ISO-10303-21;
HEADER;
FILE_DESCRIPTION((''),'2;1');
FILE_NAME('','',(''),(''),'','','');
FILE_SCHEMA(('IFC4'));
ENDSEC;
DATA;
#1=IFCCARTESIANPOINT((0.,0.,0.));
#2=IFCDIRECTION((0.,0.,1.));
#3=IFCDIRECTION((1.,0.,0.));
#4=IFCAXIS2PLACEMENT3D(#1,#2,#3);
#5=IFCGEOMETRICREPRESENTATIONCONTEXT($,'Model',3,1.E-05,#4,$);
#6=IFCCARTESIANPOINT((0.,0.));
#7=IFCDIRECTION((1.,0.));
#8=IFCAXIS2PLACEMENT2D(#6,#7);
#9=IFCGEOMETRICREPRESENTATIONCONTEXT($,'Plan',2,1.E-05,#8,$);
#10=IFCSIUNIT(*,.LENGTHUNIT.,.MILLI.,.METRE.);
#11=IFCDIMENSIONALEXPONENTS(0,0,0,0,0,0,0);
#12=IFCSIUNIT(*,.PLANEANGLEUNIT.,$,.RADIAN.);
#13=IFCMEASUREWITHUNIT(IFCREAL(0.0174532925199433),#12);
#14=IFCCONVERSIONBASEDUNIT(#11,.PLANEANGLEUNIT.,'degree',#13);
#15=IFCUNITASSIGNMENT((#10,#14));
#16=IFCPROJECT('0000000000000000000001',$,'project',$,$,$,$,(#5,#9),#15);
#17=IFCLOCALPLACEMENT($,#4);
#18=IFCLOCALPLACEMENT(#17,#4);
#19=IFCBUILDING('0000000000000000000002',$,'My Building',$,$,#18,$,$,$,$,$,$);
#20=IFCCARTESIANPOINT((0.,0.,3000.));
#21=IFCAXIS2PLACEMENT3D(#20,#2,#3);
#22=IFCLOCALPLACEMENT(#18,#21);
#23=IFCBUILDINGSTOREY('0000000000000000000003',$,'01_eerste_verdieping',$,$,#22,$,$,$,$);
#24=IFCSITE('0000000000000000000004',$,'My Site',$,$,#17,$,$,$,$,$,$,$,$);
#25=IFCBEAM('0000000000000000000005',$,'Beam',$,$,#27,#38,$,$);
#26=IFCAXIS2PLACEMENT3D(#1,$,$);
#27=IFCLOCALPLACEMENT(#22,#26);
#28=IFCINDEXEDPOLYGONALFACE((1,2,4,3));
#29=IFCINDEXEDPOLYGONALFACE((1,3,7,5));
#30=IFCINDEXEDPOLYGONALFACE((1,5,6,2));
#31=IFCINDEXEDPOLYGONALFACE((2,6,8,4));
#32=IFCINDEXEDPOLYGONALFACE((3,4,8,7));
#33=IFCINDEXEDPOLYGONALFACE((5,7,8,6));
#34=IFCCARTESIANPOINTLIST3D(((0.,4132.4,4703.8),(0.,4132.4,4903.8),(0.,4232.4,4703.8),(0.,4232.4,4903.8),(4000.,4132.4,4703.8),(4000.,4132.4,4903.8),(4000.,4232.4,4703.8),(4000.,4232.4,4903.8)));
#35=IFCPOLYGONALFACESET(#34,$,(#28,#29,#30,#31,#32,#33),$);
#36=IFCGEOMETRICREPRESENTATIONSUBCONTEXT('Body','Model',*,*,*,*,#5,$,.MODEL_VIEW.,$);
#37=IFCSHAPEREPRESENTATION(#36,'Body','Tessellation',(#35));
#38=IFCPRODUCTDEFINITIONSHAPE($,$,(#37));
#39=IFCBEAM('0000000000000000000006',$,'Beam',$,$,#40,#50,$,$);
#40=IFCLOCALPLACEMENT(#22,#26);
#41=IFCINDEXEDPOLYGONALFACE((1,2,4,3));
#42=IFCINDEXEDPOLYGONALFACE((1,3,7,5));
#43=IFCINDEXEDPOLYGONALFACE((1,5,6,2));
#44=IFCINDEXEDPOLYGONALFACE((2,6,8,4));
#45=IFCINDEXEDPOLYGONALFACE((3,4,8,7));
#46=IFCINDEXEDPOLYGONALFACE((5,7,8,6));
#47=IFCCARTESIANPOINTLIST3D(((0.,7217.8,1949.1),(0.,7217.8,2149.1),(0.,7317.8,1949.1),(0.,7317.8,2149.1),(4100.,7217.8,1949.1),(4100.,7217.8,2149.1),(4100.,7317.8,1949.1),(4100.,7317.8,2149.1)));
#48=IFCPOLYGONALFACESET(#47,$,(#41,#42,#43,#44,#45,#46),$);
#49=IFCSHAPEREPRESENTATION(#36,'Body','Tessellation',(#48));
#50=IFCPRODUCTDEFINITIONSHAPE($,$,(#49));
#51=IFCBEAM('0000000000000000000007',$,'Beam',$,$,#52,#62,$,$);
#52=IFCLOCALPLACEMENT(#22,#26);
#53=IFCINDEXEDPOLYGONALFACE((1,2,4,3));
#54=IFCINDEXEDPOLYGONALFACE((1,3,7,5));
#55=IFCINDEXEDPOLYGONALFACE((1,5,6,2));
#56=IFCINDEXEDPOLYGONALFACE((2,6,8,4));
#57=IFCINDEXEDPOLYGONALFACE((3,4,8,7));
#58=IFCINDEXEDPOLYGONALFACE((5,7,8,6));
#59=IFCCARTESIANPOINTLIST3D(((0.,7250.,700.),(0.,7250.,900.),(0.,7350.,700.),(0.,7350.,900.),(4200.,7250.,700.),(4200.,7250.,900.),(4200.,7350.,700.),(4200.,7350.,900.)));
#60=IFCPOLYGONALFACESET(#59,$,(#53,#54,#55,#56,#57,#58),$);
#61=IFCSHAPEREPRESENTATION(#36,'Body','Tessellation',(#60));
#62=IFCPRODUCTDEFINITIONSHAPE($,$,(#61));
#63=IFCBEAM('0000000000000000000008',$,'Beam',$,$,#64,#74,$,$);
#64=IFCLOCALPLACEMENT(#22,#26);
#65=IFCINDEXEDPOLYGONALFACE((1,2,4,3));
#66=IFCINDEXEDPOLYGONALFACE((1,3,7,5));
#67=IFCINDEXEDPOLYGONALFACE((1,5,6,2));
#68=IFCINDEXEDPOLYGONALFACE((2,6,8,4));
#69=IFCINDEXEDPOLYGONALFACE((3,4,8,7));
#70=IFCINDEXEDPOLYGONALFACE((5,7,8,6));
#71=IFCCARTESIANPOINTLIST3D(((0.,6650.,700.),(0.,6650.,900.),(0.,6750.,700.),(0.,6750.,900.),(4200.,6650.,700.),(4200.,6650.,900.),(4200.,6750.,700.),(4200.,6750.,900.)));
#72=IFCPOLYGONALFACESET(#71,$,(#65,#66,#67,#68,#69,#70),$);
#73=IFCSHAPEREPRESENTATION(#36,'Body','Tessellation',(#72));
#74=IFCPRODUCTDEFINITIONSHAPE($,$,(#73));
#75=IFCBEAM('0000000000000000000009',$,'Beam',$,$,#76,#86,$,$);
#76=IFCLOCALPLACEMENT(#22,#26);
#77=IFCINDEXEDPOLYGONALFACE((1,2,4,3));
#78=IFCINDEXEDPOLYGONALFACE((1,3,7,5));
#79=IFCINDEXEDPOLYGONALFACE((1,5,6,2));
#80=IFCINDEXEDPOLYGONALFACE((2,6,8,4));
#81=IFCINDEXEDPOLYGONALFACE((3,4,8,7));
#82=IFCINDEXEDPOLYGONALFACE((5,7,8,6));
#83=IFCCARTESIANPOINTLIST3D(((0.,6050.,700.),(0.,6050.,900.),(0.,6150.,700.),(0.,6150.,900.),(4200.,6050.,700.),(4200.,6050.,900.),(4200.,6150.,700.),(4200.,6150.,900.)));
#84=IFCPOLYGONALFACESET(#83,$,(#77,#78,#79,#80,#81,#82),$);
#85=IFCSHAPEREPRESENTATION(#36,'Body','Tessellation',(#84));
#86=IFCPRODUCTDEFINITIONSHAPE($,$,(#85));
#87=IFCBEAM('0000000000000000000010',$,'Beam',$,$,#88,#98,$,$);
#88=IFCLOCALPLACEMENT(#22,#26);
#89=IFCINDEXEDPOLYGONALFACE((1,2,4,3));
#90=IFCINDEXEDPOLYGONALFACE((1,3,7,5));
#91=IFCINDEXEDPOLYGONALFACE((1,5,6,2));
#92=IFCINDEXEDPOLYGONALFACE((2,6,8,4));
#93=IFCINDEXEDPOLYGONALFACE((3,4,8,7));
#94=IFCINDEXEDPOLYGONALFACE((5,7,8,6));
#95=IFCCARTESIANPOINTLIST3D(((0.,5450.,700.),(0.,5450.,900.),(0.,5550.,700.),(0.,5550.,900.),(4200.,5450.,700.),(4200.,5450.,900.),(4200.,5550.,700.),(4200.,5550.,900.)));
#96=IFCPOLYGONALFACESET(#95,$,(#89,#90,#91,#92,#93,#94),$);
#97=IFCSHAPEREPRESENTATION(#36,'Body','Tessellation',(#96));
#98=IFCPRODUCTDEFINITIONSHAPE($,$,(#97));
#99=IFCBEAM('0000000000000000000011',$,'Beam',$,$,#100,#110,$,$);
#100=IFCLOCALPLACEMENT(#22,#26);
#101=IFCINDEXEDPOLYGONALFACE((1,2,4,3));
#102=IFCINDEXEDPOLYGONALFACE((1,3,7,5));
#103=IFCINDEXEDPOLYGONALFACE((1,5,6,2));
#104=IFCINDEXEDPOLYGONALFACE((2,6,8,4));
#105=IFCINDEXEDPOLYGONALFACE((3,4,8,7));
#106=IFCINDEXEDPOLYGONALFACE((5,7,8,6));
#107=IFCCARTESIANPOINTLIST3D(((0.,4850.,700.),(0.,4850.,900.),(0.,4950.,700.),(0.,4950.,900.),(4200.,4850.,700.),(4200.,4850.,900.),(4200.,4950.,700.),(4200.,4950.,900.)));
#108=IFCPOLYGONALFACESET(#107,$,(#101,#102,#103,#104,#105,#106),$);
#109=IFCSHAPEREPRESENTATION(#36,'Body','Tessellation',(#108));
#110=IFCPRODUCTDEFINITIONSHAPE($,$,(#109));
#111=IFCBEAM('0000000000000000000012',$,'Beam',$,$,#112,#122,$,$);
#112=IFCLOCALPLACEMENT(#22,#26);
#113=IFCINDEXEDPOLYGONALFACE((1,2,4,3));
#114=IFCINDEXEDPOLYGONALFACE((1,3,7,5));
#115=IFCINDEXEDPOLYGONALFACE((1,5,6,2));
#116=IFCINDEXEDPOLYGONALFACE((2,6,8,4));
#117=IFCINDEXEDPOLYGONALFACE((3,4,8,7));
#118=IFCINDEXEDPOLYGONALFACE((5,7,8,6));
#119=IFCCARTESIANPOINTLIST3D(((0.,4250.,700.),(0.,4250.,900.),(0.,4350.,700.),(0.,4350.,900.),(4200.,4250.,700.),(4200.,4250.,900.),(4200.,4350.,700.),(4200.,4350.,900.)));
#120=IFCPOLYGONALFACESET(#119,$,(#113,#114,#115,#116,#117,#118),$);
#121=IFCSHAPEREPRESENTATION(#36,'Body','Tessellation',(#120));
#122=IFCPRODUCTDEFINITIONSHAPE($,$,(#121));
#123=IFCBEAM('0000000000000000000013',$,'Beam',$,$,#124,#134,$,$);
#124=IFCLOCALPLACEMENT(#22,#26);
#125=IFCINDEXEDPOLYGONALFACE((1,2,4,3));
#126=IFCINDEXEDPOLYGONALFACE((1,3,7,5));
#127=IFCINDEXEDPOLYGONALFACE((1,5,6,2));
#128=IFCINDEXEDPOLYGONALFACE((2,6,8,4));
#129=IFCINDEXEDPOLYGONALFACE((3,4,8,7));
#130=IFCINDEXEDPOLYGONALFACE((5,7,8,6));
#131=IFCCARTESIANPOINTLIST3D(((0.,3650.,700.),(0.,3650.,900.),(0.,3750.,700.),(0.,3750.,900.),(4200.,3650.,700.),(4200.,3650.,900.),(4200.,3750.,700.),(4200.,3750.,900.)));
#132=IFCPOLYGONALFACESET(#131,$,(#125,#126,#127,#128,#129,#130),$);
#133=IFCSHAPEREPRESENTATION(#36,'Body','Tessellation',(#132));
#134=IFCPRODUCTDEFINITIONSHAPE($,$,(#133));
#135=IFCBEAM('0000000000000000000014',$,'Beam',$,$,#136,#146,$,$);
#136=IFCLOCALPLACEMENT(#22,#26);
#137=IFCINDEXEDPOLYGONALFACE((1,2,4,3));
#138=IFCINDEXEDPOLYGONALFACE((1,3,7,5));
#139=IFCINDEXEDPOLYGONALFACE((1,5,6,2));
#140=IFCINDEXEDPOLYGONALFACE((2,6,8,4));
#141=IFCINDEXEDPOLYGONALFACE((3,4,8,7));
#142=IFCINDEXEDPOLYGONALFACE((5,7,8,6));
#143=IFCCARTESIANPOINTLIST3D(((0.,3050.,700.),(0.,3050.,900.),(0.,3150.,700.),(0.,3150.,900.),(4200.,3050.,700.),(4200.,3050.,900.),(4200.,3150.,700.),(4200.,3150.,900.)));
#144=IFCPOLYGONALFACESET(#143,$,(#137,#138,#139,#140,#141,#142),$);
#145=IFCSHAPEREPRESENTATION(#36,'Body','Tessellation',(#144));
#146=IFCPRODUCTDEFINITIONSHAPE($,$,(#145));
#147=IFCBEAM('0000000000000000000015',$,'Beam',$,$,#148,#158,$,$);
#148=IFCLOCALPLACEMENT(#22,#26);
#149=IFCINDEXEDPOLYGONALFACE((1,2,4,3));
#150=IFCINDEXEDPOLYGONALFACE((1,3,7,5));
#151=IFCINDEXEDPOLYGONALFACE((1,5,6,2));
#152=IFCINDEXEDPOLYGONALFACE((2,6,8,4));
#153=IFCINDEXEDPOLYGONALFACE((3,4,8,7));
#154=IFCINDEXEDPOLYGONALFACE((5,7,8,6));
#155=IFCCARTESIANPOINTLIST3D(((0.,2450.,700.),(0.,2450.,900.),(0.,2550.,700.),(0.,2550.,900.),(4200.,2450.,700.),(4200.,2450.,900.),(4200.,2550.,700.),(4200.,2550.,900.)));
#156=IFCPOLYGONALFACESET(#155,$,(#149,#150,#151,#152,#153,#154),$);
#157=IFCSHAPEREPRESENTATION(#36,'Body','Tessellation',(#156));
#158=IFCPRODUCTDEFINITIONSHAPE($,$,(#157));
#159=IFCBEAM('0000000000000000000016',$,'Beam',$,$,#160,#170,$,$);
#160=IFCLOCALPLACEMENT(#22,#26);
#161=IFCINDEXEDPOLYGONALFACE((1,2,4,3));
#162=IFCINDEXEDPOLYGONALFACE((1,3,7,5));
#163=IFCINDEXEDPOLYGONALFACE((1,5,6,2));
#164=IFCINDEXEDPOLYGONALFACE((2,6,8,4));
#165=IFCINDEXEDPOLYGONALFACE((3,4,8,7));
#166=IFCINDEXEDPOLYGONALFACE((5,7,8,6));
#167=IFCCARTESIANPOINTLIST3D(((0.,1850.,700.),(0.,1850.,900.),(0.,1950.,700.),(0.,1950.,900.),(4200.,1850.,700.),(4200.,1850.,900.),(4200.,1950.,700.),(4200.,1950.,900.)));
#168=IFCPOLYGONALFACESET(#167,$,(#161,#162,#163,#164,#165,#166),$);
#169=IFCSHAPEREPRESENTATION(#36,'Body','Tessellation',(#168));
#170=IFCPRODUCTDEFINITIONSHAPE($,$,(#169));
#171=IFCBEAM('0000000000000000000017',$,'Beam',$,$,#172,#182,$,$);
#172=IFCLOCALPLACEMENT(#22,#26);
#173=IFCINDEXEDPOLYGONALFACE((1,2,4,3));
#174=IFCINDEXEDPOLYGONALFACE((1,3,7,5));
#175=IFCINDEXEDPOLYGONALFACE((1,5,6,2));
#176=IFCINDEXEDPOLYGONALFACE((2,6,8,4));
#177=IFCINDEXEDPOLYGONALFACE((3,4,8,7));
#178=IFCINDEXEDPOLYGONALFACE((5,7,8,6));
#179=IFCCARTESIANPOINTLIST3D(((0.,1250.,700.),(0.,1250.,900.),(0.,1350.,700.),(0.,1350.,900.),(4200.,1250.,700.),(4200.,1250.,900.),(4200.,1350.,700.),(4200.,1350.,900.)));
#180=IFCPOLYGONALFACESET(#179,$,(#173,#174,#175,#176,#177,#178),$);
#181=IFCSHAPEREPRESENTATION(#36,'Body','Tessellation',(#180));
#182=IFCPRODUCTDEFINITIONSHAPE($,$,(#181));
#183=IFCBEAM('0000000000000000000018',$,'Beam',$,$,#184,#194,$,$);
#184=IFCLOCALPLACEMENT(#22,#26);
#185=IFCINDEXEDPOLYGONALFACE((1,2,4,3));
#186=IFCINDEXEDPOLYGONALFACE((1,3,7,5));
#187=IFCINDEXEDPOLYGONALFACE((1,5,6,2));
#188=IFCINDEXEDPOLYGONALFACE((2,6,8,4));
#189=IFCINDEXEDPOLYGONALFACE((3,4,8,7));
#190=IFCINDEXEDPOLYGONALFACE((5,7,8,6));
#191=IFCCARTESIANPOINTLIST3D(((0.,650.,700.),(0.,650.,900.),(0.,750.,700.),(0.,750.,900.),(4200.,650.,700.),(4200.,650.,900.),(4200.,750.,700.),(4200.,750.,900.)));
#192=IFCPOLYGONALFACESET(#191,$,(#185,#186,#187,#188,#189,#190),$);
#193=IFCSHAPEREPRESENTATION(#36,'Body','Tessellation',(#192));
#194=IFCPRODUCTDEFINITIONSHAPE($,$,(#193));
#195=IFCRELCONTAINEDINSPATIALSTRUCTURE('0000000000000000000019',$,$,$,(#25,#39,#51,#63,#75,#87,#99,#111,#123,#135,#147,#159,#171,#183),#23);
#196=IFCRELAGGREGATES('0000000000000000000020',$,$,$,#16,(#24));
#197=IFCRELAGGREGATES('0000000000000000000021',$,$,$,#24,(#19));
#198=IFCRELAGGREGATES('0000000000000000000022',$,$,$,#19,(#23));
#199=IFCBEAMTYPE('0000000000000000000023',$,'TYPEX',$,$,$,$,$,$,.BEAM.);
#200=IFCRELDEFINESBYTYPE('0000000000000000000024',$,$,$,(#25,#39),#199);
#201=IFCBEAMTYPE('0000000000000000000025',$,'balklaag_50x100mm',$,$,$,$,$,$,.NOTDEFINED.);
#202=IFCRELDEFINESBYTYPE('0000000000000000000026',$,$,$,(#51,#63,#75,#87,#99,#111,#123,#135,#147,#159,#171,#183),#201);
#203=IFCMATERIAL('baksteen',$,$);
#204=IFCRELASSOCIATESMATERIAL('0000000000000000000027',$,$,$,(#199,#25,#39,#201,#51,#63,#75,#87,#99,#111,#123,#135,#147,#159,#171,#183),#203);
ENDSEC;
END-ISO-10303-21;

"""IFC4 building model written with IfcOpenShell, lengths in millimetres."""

from ifc_helpers import new_model, entity, si_unit, converted_unit, frame, origin_with_axes, origin_2d_with_axis, place, context, subcontext, project, spatial, rectangle, extrude, material, material_profile, profile_set, profile_usage, type_object, element, save


model = new_model("IFC4")

# Units and contexts
model_context = context("Model", 3, precision=1e-05, world=origin_with_axes())
plan_context = context("Plan", 2, precision=1e-05, world=origin_2d_with_axis())
body_context = subcontext(model_context, "Body", "Model", "MODEL_VIEW")
ifc_project = project(units=[si_unit("LENGTHUNIT", "METRE", prefix="MILLI"), converted_unit("PLANEANGLEUNIT", "degree", entity("IfcReal", 0.0174532925199433), si_unit("PLANEANGLEUNIT", "RADIAN"), dimensions=[0, 0, 0, 0, 0, 0, 0])], contexts=[model_context, plan_context])

# Site, building, storey
site_placement = place(None, origin_with_axes())
site = spatial("IfcSite", under=ifc_project, at=site_placement, Name="My Site")
building_placement = place(site_placement, origin_with_axes())
building = spatial("IfcBuilding", under=site, at=building_placement, Name="My Building")
storey_placement = place(building_placement, frame((0.0, 0.0, 3000.0), z_axis=(0.0, 0.0, 1.0), x_axis=(1.0, 0.0, 0.0)))
storey = spatial("IfcBuildingStorey", under=building, at=storey_placement, Name="01_eerste_verdieping")

# Beams
ifc_material = material(Name="baksteen")
ifc_material_profile_1 = material_profile(ifc_material, rectangle(XDim=100.0, YDim=200.0))
ifc_profile_set_1 = profile_set([ifc_material_profile_1])
ifc_profile_usage_1 = profile_usage(ifc_profile_set_1, cardinal=5)
beam_type_1 = type_object("IfcBeamType", Name="TYPEX", PredefinedType="BEAM", material=ifc_profile_set_1)
beam_1_placement = place(storey_placement, frame((0.0, 4182.4, 4803.8), z_axis=(1.0, 0.0, 0.0), x_axis=(0.0, 1.0, 0.0)))
element("IfcBeam", 1, at=beam_1_placement, inside=storey, type_object=beam_type_1, material=ifc_profile_usage_1, Name="Beam", context=body_context, shape_type="SweptSolid", body=[
    extrude(rectangle(XDim=100.0, YDim=200.0), origin_with_axes(), (0.0, 0.0, 1.0), 4000.0),
])
ifc_profile_usage_2 = profile_usage(ifc_profile_set_1, cardinal=5)
beam_2_placement = place(storey_placement, frame((0.0, 7267.8, 2049.1), z_axis=(1.0, 0.0, 0.0), x_axis=(0.0, 1.0, 0.0)))
element("IfcBeam", 2, at=beam_2_placement, inside=storey, type_object=beam_type_1, material=ifc_profile_usage_2, Name="Beam", context=body_context, shape_type="SweptSolid", body=[
    extrude(rectangle(XDim=100.0, YDim=200.0), origin_with_axes(), (0.0, 0.0, 1.0), 4100.0),
])
ifc_material_profile_2 = material_profile(ifc_material, rectangle(XDim=100.0, YDim=200.0))
ifc_profile_set_2 = profile_set([ifc_material_profile_2])
ifc_profile_usage_3 = profile_usage(ifc_profile_set_2, cardinal=5)
beam_type_2 = type_object("IfcBeamType", Name="balklaag_50x100mm", PredefinedType="NOTDEFINED", material=ifc_profile_set_2)
beam_3_placement = place(storey_placement, frame((4200.0, 7300.0, 800.0), z_axis=(-1.0, 0.0, 0.0), x_axis=(0.0, -1.0, 0.0)))
element("IfcBeam", 3, at=beam_3_placement, inside=storey, type_object=beam_type_2, material=ifc_profile_usage_3, Name="Beam", context=body_context, shape_type="SweptSolid", body=[
    extrude(rectangle(XDim=100.0, YDim=200.0), origin_with_axes(), (0.0, 0.0, 1.0), 4200.0),
])
ifc_profile_usage_4 = profile_usage(ifc_profile_set_2, cardinal=5)
beam_4_placement = place(storey_placement, frame((4200.0, 6700.0, 800.0), z_axis=(-1.0, 0.0, 0.0), x_axis=(0.0, -1.0, 0.0)))
element("IfcBeam", 4, at=beam_4_placement, inside=storey, type_object=beam_type_2, material=ifc_profile_usage_4, Name="Beam", context=body_context, shape_type="SweptSolid", body=[
    extrude(rectangle(XDim=100.0, YDim=200.0), origin_with_axes(), (0.0, 0.0, 1.0), 4200.0),
])
ifc_profile_usage_5 = profile_usage(ifc_profile_set_2, cardinal=5)
beam_5_placement = place(storey_placement, frame((4200.0, 6100.0, 800.0), z_axis=(-1.0, 0.0, 0.0), x_axis=(0.0, -1.0, 0.0)))
element("IfcBeam", 5, at=beam_5_placement, inside=storey, type_object=beam_type_2, material=ifc_profile_usage_5, Name="Beam", context=body_context, shape_type="SweptSolid", body=[
    extrude(rectangle(XDim=100.0, YDim=200.0), origin_with_axes(), (0.0, 0.0, 1.0), 4200.0),
])
ifc_profile_usage_6 = profile_usage(ifc_profile_set_2, cardinal=5)
beam_6_placement = place(storey_placement, frame((4200.0, 5500.0, 800.0), z_axis=(-1.0, 0.0, 0.0), x_axis=(0.0, -1.0, 0.0)))
element("IfcBeam", 6, at=beam_6_placement, inside=storey, type_object=beam_type_2, material=ifc_profile_usage_6, Name="Beam", context=body_context, shape_type="SweptSolid", body=[
    extrude(rectangle(XDim=100.0, YDim=200.0), origin_with_axes(), (0.0, 0.0, 1.0), 4200.0),
])
ifc_profile_usage_7 = profile_usage(ifc_profile_set_2, cardinal=5)
beam_7_placement = place(storey_placement, frame((4200.0, 4900.0, 800.0), z_axis=(-1.0, 0.0, 0.0), x_axis=(0.0, -1.0, 0.0)))
element("IfcBeam", 7, at=beam_7_placement, inside=storey, type_object=beam_type_2, material=ifc_profile_usage_7, Name="Beam", context=body_context, shape_type="SweptSolid", body=[
    extrude(rectangle(XDim=100.0, YDim=200.0), origin_with_axes(), (0.0, 0.0, 1.0), 4200.0),
])
ifc_profile_usage_8 = profile_usage(ifc_profile_set_2, cardinal=5)
beam_8_placement = place(storey_placement, frame((4200.0, 4300.0, 800.0), z_axis=(-1.0, 0.0, 0.0), x_axis=(0.0, -1.0, 0.0)))
element("IfcBeam", 8, at=beam_8_placement, inside=storey, type_object=beam_type_2, material=ifc_profile_usage_8, Name="Beam", context=body_context, shape_type="SweptSolid", body=[
    extrude(rectangle(XDim=100.0, YDim=200.0), origin_with_axes(), (0.0, 0.0, 1.0), 4200.0),
])
ifc_profile_usage_9 = profile_usage(ifc_profile_set_2, cardinal=5)
beam_9_placement = place(storey_placement, frame((4200.0, 3700.0, 800.0), z_axis=(-1.0, 0.0, 0.0), x_axis=(0.0, -1.0, 0.0)))
element("IfcBeam", 9, at=beam_9_placement, inside=storey, type_object=beam_type_2, material=ifc_profile_usage_9, Name="Beam", context=body_context, shape_type="SweptSolid", body=[
    extrude(rectangle(XDim=100.0, YDim=200.0), origin_with_axes(), (0.0, 0.0, 1.0), 4200.0),
])
ifc_profile_usage_10 = profile_usage(ifc_profile_set_2, cardinal=5)
beam_10_placement = place(storey_placement, frame((4200.0, 3100.0, 800.0), z_axis=(-1.0, 0.0, 0.0), x_axis=(0.0, -1.0, 0.0)))
element("IfcBeam", 10, at=beam_10_placement, inside=storey, type_object=beam_type_2, material=ifc_profile_usage_10, Name="Beam", context=body_context, shape_type="SweptSolid", body=[
    extrude(rectangle(XDim=100.0, YDim=200.0), origin_with_axes(), (0.0, 0.0, 1.0), 4200.0),
])
ifc_profile_usage_11 = profile_usage(ifc_profile_set_2, cardinal=5)
beam_11_placement = place(storey_placement, frame((4200.0, 2500.0, 800.0), z_axis=(-1.0, 0.0, 0.0), x_axis=(0.0, -1.0, 0.0)))
element("IfcBeam", 11, at=beam_11_placement, inside=storey, type_object=beam_type_2, material=ifc_profile_usage_11, Name="Beam", context=body_context, shape_type="SweptSolid", body=[
    extrude(rectangle(XDim=100.0, YDim=200.0), origin_with_axes(), (0.0, 0.0, 1.0), 4200.0),
])
ifc_profile_usage_12 = profile_usage(ifc_profile_set_2, cardinal=5)
beam_12_placement = place(storey_placement, frame((4200.0, 1900.0, 800.0), z_axis=(-1.0, 0.0, 0.0), x_axis=(0.0, -1.0, 0.0)))
element("IfcBeam", 12, at=beam_12_placement, inside=storey, type_object=beam_type_2, material=ifc_profile_usage_12, Name="Beam", context=body_context, shape_type="SweptSolid", body=[
    extrude(rectangle(XDim=100.0, YDim=200.0), origin_with_axes(), (0.0, 0.0, 1.0), 4200.0),
])
ifc_profile_usage_13 = profile_usage(ifc_profile_set_2, cardinal=5)
beam_13_placement = place(storey_placement, frame((4200.0, 1300.0, 800.0), z_axis=(-1.0, 0.0, 0.0), x_axis=(0.0, -1.0, 0.0)))
element("IfcBeam", 13, at=beam_13_placement, inside=storey, type_object=beam_type_2, material=ifc_profile_usage_13, Name="Beam", context=body_context, shape_type="SweptSolid", body=[
    extrude(rectangle(XDim=100.0, YDim=200.0), origin_with_axes(), (0.0, 0.0, 1.0), 4200.0),
])
ifc_profile_usage_14 = profile_usage(ifc_profile_set_2, cardinal=5)
beam_14_placement = place(storey_placement, frame((4200.0, 700.0, 800.0), z_axis=(-1.0, 0.0, 0.0), x_axis=(0.0, -1.0, 0.0)))
element("IfcBeam", 14, at=beam_14_placement, inside=storey, type_object=beam_type_2, material=ifc_profile_usage_14, Name="Beam", context=body_context, shape_type="SweptSolid", body=[
    extrude(rectangle(XDim=100.0, YDim=200.0), origin_with_axes(), (0.0, 0.0, 1.0), 4200.0),
])

save(model, "model.ifc")
